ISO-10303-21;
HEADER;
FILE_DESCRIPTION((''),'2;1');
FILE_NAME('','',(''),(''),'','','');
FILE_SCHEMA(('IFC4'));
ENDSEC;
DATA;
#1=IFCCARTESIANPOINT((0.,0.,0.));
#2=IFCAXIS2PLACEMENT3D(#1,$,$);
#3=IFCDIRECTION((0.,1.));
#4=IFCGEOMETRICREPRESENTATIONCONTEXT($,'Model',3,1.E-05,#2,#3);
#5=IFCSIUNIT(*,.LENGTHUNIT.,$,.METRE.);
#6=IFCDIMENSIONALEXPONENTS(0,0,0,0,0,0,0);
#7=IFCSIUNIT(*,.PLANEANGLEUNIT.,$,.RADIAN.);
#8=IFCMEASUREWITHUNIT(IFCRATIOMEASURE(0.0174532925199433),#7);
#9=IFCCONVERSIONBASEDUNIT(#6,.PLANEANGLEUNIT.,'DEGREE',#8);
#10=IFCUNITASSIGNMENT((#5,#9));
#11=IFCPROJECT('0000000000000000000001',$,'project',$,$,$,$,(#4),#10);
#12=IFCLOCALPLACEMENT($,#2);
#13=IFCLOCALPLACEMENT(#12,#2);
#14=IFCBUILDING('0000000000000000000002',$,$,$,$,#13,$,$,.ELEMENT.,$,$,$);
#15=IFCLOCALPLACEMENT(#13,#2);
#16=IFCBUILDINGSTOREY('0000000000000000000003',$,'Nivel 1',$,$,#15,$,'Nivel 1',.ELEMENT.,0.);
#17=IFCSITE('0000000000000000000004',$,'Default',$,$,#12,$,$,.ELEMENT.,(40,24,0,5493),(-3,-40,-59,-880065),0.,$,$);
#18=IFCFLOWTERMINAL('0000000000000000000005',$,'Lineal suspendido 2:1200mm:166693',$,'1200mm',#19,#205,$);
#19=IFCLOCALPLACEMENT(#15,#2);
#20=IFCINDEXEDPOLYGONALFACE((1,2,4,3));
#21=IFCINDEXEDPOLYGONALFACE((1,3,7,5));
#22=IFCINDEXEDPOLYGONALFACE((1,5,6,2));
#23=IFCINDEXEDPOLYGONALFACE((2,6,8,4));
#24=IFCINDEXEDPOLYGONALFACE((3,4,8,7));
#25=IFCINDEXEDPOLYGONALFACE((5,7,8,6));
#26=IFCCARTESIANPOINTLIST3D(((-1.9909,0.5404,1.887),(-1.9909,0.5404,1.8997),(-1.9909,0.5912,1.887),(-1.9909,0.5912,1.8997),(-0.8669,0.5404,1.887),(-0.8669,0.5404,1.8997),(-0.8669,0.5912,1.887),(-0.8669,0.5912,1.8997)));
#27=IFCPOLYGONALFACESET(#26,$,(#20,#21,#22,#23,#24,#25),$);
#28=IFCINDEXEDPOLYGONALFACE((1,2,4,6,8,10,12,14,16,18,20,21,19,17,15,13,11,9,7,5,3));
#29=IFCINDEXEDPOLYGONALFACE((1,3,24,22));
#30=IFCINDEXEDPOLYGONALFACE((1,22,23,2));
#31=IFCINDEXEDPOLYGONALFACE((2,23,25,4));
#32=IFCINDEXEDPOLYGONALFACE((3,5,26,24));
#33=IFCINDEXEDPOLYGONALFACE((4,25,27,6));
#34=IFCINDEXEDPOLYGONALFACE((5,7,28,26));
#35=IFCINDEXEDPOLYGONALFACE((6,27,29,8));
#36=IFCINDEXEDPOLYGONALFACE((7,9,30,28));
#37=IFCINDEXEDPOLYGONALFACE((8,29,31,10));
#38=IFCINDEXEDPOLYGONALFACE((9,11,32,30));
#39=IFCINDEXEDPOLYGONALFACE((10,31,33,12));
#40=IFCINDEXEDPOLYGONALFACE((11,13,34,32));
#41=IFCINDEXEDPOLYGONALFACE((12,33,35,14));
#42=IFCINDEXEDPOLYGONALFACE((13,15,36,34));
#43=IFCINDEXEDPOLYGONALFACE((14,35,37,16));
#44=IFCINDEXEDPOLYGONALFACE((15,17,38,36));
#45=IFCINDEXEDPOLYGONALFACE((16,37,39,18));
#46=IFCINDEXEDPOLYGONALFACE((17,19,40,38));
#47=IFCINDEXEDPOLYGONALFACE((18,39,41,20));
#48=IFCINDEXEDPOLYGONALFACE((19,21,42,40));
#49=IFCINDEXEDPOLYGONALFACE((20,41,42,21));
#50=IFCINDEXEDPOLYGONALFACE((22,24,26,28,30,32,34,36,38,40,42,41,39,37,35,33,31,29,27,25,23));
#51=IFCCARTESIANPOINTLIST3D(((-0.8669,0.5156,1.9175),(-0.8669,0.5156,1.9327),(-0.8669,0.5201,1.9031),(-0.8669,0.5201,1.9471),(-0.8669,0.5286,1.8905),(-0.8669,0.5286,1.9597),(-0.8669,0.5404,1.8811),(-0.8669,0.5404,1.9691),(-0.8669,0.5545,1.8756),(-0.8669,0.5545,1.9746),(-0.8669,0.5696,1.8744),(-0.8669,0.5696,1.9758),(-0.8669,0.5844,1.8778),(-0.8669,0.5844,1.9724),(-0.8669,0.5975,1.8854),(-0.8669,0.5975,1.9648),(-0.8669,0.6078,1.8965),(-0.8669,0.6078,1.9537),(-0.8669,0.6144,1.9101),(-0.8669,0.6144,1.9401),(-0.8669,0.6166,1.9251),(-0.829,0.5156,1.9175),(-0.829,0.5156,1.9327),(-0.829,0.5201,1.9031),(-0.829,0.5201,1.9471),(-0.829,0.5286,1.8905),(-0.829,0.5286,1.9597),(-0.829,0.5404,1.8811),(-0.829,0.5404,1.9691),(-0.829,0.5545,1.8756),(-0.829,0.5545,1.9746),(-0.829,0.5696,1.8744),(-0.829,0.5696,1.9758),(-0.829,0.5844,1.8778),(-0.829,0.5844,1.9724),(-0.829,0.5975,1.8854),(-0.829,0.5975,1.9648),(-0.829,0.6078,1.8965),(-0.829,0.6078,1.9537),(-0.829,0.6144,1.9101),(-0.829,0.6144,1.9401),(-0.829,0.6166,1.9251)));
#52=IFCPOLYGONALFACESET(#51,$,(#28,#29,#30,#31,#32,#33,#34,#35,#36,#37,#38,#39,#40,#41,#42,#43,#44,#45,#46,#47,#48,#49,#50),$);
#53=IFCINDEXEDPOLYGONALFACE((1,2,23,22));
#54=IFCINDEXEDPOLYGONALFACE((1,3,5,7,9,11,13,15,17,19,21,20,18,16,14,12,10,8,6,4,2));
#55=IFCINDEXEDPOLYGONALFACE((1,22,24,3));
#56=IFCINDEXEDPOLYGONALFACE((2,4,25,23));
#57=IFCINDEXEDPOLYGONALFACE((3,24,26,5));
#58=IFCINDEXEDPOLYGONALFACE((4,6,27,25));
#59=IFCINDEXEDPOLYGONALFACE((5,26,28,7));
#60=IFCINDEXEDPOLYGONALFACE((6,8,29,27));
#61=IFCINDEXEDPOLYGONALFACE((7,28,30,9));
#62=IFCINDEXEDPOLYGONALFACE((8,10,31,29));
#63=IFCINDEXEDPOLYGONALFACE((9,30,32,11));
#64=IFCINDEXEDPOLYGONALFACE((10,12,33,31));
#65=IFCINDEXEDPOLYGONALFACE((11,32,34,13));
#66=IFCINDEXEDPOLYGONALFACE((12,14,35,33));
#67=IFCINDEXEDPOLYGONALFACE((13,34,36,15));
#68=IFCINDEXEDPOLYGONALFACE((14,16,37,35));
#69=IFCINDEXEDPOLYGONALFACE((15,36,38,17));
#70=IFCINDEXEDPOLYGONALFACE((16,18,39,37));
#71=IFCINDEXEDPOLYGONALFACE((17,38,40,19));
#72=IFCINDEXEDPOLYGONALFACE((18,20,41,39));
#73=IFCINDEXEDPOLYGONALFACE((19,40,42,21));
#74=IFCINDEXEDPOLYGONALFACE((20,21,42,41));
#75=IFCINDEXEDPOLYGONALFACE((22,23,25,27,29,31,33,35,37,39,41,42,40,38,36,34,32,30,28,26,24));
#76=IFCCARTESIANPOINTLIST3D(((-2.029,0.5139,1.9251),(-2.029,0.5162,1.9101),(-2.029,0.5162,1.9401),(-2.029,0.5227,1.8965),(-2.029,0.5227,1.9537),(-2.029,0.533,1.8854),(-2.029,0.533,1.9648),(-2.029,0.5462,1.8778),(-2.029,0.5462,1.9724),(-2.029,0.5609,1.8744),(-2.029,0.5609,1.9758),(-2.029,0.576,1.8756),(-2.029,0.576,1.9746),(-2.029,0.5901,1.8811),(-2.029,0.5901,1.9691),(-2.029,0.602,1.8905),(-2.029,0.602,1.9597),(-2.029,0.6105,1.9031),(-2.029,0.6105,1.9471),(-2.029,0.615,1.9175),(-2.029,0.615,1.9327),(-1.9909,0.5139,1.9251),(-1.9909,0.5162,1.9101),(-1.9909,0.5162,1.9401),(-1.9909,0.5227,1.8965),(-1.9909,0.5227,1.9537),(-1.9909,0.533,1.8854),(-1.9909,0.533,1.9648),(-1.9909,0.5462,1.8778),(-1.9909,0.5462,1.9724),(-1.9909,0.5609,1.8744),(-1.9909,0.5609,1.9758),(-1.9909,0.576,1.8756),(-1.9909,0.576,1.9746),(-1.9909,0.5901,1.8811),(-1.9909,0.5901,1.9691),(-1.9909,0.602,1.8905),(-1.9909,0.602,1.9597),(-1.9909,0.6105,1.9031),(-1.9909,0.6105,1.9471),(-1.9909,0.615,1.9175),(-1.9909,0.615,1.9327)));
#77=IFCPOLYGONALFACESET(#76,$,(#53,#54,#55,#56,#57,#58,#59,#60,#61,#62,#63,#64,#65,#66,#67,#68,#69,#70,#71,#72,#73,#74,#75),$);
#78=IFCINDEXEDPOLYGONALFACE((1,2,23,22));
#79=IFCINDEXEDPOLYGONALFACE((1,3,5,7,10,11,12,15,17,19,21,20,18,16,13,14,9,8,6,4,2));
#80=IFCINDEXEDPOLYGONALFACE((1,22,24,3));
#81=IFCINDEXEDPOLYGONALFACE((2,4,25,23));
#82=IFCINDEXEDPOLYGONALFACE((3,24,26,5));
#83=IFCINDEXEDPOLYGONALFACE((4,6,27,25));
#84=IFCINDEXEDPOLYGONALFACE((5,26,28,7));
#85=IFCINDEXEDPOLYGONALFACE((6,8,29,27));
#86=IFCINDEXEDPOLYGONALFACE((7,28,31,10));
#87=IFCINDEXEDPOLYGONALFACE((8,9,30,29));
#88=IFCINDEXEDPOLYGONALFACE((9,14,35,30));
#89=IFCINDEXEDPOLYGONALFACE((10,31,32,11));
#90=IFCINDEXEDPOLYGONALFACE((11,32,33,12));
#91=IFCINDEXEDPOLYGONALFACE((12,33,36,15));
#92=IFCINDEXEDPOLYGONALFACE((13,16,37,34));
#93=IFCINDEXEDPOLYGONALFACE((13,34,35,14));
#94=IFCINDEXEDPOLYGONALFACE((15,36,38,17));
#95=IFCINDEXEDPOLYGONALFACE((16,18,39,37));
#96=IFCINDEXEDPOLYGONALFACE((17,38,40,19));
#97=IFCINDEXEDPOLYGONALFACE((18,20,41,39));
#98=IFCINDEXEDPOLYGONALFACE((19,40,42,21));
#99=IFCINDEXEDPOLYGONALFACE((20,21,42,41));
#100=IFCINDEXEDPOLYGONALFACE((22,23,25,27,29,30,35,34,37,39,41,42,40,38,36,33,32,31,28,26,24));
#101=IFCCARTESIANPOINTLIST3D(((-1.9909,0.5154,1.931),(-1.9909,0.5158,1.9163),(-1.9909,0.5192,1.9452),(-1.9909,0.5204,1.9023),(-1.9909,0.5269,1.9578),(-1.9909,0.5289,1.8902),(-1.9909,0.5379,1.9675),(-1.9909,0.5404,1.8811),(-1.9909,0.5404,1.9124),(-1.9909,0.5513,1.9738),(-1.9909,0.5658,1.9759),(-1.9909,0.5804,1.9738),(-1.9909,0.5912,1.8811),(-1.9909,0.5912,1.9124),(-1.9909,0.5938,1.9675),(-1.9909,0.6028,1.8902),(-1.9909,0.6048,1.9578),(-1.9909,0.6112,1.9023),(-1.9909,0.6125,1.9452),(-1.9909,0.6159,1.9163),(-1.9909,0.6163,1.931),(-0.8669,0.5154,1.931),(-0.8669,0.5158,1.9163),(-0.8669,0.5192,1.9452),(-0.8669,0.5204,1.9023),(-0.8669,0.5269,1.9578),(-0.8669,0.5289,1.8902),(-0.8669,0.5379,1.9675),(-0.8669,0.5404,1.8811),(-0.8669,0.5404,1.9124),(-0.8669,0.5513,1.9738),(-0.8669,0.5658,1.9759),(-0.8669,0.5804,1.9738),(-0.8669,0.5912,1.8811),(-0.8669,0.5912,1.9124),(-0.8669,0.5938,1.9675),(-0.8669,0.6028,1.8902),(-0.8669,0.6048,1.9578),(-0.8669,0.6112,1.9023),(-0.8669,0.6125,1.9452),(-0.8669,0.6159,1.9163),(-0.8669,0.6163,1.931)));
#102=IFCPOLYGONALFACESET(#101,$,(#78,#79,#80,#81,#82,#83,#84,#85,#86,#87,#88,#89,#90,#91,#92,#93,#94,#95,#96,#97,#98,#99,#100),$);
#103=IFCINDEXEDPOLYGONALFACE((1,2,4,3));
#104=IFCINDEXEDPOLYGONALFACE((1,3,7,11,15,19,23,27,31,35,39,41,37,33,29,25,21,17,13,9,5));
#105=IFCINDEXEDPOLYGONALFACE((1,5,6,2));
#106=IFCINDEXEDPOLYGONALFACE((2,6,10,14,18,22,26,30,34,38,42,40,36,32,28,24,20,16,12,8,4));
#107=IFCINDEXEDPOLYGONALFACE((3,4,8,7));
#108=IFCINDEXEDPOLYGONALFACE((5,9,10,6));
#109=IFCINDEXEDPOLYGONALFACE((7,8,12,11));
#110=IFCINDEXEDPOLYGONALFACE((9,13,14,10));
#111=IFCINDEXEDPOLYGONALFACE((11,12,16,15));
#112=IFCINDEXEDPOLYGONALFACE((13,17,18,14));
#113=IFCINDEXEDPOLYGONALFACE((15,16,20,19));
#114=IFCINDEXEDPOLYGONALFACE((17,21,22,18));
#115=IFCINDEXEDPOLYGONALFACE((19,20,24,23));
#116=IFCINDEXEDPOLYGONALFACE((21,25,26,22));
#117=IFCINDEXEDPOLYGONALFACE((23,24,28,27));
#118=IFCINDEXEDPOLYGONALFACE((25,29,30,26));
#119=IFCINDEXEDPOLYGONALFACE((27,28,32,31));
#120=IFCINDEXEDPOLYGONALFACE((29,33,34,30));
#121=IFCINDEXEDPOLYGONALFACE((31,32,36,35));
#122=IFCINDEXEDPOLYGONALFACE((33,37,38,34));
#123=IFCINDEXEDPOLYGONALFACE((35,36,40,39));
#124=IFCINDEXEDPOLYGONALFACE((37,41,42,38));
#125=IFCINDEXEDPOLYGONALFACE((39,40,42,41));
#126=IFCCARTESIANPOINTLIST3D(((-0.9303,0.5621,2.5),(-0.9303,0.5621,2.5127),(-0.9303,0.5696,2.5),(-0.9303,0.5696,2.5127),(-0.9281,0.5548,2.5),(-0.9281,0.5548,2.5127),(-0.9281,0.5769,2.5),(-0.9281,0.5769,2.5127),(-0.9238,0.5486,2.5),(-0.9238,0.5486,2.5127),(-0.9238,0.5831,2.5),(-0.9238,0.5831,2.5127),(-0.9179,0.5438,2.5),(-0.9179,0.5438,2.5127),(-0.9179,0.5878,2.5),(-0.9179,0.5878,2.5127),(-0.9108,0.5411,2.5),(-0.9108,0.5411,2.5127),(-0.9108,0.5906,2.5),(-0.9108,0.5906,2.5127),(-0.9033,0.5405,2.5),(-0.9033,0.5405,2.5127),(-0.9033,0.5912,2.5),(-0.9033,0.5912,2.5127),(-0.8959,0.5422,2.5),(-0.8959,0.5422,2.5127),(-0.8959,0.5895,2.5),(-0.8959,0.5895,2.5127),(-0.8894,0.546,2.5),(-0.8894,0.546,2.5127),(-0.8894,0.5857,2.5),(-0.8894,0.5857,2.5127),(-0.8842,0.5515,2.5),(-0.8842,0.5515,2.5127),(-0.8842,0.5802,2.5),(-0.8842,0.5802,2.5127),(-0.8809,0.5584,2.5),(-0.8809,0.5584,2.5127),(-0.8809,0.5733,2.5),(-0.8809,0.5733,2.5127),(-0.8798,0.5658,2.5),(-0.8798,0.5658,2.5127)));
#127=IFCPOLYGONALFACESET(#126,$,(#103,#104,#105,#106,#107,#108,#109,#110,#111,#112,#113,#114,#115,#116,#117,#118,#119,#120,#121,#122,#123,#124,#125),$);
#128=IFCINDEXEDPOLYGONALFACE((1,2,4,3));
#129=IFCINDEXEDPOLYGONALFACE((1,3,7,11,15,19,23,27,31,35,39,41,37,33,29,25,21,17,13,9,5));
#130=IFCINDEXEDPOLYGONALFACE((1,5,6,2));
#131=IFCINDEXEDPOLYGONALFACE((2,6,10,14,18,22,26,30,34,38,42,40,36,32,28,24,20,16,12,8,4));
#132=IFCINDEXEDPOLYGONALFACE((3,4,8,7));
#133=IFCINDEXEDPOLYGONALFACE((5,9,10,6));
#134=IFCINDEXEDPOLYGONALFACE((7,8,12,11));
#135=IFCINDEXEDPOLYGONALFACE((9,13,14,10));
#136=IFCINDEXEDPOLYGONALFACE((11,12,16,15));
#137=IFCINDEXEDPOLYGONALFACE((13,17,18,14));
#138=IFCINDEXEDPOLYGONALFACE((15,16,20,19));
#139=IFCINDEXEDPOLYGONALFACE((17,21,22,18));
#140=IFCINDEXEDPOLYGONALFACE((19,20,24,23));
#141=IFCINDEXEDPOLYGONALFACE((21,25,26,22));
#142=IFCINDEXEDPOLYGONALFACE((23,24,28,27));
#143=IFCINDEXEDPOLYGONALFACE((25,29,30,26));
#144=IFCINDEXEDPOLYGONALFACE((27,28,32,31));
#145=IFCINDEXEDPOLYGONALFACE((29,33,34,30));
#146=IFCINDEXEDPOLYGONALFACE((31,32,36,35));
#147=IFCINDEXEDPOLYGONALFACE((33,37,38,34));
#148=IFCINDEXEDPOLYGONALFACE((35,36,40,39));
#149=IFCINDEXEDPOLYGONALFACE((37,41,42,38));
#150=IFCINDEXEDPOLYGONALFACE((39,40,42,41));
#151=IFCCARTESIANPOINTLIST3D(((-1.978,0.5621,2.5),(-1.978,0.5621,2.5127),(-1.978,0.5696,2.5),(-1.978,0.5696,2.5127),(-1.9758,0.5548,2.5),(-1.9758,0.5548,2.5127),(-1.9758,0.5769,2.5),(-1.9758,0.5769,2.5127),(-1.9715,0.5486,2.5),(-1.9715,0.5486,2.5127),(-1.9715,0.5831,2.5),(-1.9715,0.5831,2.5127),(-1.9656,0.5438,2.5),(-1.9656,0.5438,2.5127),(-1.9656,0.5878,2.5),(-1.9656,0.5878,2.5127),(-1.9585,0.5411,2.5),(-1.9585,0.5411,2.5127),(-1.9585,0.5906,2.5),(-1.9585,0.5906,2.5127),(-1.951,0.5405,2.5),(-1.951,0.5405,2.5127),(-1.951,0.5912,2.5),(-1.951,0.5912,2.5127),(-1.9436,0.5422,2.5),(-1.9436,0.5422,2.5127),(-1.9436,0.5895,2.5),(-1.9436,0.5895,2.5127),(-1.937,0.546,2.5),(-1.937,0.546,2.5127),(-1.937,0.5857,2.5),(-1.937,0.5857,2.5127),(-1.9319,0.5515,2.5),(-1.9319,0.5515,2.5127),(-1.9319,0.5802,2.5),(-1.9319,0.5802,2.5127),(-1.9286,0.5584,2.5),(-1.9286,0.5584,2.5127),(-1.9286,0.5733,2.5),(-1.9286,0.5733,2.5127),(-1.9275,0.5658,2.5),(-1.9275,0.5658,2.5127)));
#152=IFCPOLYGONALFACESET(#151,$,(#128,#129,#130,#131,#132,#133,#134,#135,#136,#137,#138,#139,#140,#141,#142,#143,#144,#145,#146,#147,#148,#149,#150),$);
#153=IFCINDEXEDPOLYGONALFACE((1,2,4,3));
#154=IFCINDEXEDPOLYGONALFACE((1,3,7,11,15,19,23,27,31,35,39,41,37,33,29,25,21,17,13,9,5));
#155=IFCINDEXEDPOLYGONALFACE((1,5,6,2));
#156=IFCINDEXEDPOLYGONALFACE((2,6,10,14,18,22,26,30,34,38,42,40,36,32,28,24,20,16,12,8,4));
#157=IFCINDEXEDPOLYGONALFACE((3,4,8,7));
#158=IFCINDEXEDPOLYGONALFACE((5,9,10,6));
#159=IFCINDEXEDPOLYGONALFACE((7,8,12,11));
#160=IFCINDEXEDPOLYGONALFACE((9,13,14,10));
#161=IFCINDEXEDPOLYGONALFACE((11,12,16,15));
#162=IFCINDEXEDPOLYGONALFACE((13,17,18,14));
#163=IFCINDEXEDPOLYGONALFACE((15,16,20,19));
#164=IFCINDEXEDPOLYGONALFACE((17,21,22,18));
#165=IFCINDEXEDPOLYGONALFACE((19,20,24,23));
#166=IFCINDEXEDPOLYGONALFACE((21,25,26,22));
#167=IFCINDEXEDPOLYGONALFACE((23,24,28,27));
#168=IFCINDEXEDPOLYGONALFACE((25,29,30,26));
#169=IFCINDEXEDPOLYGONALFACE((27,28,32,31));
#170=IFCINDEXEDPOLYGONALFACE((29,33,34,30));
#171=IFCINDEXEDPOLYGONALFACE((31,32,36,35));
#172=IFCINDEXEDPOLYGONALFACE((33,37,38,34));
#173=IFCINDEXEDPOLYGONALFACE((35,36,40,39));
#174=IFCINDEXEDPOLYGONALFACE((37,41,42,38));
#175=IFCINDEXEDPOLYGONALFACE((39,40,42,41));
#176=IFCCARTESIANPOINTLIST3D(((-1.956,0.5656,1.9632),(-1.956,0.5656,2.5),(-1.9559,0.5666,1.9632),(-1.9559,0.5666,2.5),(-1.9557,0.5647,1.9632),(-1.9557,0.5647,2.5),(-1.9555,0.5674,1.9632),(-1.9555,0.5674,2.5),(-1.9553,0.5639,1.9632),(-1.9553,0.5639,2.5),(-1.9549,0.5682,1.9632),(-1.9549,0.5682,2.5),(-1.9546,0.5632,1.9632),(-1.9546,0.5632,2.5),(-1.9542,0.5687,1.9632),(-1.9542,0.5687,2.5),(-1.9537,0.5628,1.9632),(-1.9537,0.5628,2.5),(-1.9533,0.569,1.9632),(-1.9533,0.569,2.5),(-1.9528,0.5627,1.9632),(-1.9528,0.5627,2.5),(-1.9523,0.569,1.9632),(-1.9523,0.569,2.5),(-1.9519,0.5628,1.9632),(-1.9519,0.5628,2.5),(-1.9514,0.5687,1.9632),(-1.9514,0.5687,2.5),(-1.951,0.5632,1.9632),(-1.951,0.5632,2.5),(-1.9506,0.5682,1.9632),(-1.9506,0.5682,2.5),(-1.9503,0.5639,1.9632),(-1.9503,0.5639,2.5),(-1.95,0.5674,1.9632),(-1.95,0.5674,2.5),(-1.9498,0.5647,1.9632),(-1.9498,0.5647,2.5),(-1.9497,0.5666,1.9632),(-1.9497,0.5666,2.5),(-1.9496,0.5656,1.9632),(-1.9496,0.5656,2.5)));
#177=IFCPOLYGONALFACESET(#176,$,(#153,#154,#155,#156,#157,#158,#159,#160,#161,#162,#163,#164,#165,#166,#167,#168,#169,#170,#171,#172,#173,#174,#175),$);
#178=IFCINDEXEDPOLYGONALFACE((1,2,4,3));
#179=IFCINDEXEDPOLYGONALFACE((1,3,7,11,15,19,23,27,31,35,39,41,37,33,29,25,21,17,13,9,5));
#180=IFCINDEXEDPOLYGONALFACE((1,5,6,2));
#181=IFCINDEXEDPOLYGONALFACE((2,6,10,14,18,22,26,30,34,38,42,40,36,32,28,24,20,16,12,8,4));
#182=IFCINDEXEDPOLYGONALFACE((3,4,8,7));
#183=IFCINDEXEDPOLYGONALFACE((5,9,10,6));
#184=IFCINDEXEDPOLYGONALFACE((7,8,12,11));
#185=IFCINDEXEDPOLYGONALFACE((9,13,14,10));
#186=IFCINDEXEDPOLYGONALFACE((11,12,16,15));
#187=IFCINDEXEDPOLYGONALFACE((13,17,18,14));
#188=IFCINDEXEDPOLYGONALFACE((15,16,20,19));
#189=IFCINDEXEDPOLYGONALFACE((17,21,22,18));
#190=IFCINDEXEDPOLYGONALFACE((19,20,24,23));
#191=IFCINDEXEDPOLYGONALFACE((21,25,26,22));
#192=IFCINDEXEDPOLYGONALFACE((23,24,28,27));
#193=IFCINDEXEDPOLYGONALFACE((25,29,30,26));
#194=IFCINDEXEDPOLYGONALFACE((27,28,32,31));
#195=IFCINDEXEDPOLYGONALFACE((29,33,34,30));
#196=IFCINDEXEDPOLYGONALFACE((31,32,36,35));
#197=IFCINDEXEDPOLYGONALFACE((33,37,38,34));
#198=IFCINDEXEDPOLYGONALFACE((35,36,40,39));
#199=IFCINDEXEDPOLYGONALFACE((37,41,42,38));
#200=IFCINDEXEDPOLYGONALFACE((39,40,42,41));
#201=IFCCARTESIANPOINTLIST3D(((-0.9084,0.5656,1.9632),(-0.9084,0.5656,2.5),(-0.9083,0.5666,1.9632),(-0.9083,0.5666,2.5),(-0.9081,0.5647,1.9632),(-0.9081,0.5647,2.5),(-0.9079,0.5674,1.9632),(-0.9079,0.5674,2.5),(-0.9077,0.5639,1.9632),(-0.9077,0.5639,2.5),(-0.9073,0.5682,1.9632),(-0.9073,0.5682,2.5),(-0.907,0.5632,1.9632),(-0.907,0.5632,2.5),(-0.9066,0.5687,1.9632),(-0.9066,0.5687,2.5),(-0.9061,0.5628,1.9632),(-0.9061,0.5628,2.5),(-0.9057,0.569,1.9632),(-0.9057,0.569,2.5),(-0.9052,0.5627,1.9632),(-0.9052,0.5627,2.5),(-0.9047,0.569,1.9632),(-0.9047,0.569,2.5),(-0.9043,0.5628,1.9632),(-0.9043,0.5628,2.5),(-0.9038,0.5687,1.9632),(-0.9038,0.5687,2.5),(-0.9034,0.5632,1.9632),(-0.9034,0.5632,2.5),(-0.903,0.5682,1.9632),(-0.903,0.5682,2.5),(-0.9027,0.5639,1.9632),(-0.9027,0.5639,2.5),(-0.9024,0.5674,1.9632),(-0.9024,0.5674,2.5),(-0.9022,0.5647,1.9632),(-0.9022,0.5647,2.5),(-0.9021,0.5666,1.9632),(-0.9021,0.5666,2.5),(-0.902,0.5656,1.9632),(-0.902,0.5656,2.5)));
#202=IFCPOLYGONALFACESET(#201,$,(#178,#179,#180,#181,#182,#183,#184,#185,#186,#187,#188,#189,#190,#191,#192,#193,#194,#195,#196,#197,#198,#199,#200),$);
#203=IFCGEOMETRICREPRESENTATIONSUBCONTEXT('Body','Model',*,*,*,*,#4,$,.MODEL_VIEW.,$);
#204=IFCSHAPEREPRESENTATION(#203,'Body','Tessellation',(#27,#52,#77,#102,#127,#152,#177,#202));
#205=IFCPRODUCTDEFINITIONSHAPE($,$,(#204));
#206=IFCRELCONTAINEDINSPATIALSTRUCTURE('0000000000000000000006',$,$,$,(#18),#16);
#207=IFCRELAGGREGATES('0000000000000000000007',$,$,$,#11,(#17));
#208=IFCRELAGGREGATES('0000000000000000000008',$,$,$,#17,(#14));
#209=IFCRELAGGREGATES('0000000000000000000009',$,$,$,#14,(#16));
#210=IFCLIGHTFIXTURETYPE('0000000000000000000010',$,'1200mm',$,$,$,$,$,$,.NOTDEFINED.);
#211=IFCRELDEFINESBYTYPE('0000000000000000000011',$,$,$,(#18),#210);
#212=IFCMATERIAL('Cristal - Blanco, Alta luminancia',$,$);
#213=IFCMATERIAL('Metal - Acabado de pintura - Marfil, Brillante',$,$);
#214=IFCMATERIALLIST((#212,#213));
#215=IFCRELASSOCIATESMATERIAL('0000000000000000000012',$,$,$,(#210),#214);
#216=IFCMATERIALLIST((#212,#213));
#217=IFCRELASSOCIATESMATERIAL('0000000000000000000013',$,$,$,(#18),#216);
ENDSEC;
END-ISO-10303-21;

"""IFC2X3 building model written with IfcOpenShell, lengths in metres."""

from ifc_helpers import new_model, entity, si_unit, converted_unit, direction, frame, frame_2d, origin, origin_2d_with_axis, place, context, subcontext, project, spatial, polyline, circle_curve, parameter, trimmed, segment, composite_curve, rectangle, circle, outline, extrude, source, transform, mapped, material, material_list, type_object, type_shapes, element, save


model = new_model("IFC2X3")

# Units and contexts
model_context = context("Model", 3, precision=1e-05, world=origin(), true_north=direction((0.0, 1.0)))
body_context = subcontext(model_context, "Body", "Model", "MODEL_VIEW")
ifc_project = project(units=[si_unit("LENGTHUNIT", "METRE"), converted_unit("PLANEANGLEUNIT", "DEGREE", entity("IfcRatioMeasure", 0.0174532925199433), si_unit("PLANEANGLEUNIT", "RADIAN"), dimensions=[0, 0, 0, 0, 0, 0, 0])], contexts=[model_context])

# Site, building, storey
site_placement = place(None, origin())
site = spatial("IfcSite", under=ifc_project, at=site_placement, Name="Default", CompositionType="ELEMENT", RefLatitude=(40, 24, 0, 5493), RefLongitude=(-3, -40, -59, -880065), RefElevation=0.0)
building_placement = place(site_placement, origin())
building = spatial("IfcBuilding", under=site, at=building_placement, CompositionType="ELEMENT")
storey_placement = place(building_placement, origin())
storey = spatial("IfcBuildingStorey", under=building, at=storey_placement, Name="Nivel 1", LongName="Nivel 1", CompositionType="ELEMENT", Elevation=0.0)

# Flow terminal
ifc_material_1 = material(Name="Cristal - Blanco, Alta luminancia")
ifc_material_2 = material(Name="Metal - Acabado de pintura - Marfil, Brillante")
ifc_material_list_1 = material_list([ifc_material_1, ifc_material_2])
light_fixture_type = type_object("IfcLightFixtureType", Name="1200mm", PredefinedType="NOTDEFINED", material=ifc_material_list_1)
shared_shape = source(origin(), body_context, "Body", "SweptSolid", [
    extrude(rectangle(XDim=1.124, YDim=0.0508, at=origin_2d_with_axis()), frame((0.0001, 0.0, 1.8127), z_axis=(0.0, 0.0, 1.0), x_axis=(-1.0, 0.0, 0.0)), (0.0, 0.0, 1.0), 0.0127),
    extrude(circle(Radius=0.0508, at=frame_2d((0.0, 0.0), x_axis=(1.0, 0.0))), frame((0.5621, 0.0, 1.8508), z_axis=(1.0, 0.0, 0.0), x_axis=(0.0, 1.0, 0.0)), (0.0, 0.0, 1.0), 0.0379),
    extrude(circle(Radius=0.0508, at=frame_2d((0.0, 0.0), x_axis=(1.0, 0.0))), frame((-0.6, -0.0011, 1.8508), z_axis=(1.0, 0.0, 0.0), x_axis=(0.0, -1.0, 0.0)), (0.0, 0.0, 1.0), 0.0381),
    extrude(outline(composite_curve([segment(trimmed(circle_curve(frame_2d((0.0125, 0.0), x_axis=(0.0, 1.0)), 0.0508), [parameter(120.0)], [parameter(270.0)], True, "PARAMETER"), True, "CONTINUOUS"), segment(trimmed(circle_curve(frame_2d((0.0125, 0.0), x_axis=(0.0, 1.0)), 0.0508), [parameter(270.0)], [parameter(60.0)], True, "PARAMETER"), True, "CONTINUOUS"), segment(polyline([(-0.0315, 0.0254), (-0.0002, 0.0254)]), True, "CONTINUOUS"), segment(polyline([(-0.0002, 0.0254), (-0.0002, -0.0254)]), True, "CONTINUOUS"), segment(polyline([(-0.0002, -0.0254), (-0.0315, -0.0254)]), True, "CONTINUOUS")], self_intersect=False)), frame((-0.5619, 0.0, 1.8383), z_axis=(-1.0, 0.0, 0.0), x_axis=(0.0, 0.0, 1.0)), (0.0, 0.0, -1.0), 1.124),
    extrude(circle(Radius=0.0254, at=frame_2d((0.0, 0.0), x_axis=(1.0, 0.0))), frame((0.5238, 0.0, 2.4257)), (0.0, 0.0, 1.0), 0.0127),
    extrude(circle(Radius=0.0254, at=frame_2d((0.0, 0.0), x_axis=(1.0, 0.0))), frame((-0.5239, 0.0, 2.4257)), (0.0, 0.0, 1.0), 0.0127),
    extrude(circle(Radius=0.0032, at=frame_2d((0.0, 0.0), x_axis=(1.0, 0.0))), frame((-0.5238, 0.0, 1.8889), z_axis=(0.0, 0.0, 1.0), x_axis=(0.0, -1.0, 0.0)), (0.0, 0.0, 1.0), 0.5368),
    extrude(circle(Radius=0.0032, at=frame_2d((0.0, 0.0), x_axis=(1.0, 0.0))), frame((0.5238, 0.0, 1.8889), z_axis=(0.0, 0.0, 1.0), x_axis=(0.0, -1.0, 0.0)), (0.0, 0.0, 1.0), 0.5368),
])
type_shapes(light_fixture_type, [shared_shape])
ifc_material_list_2 = material_list([ifc_material_1, ifc_material_2])
flow_terminal_1_placement = place(storey_placement, frame((-1.429, 0.5658, 0.0743)))
element("IfcFlowTerminal", 1, at=flow_terminal_1_placement, inside=storey, type_object=light_fixture_type, material=ifc_material_list_2, Name="Lineal suspendido 2:1200mm:166693", ObjectType="1200mm", context=body_context, shape_type="MappedRepresentation", body=[
    mapped(shared_shape, transform((0.0, 0.0, 0.0), scale=1.0)),
])

save(model, "model.ifc")
